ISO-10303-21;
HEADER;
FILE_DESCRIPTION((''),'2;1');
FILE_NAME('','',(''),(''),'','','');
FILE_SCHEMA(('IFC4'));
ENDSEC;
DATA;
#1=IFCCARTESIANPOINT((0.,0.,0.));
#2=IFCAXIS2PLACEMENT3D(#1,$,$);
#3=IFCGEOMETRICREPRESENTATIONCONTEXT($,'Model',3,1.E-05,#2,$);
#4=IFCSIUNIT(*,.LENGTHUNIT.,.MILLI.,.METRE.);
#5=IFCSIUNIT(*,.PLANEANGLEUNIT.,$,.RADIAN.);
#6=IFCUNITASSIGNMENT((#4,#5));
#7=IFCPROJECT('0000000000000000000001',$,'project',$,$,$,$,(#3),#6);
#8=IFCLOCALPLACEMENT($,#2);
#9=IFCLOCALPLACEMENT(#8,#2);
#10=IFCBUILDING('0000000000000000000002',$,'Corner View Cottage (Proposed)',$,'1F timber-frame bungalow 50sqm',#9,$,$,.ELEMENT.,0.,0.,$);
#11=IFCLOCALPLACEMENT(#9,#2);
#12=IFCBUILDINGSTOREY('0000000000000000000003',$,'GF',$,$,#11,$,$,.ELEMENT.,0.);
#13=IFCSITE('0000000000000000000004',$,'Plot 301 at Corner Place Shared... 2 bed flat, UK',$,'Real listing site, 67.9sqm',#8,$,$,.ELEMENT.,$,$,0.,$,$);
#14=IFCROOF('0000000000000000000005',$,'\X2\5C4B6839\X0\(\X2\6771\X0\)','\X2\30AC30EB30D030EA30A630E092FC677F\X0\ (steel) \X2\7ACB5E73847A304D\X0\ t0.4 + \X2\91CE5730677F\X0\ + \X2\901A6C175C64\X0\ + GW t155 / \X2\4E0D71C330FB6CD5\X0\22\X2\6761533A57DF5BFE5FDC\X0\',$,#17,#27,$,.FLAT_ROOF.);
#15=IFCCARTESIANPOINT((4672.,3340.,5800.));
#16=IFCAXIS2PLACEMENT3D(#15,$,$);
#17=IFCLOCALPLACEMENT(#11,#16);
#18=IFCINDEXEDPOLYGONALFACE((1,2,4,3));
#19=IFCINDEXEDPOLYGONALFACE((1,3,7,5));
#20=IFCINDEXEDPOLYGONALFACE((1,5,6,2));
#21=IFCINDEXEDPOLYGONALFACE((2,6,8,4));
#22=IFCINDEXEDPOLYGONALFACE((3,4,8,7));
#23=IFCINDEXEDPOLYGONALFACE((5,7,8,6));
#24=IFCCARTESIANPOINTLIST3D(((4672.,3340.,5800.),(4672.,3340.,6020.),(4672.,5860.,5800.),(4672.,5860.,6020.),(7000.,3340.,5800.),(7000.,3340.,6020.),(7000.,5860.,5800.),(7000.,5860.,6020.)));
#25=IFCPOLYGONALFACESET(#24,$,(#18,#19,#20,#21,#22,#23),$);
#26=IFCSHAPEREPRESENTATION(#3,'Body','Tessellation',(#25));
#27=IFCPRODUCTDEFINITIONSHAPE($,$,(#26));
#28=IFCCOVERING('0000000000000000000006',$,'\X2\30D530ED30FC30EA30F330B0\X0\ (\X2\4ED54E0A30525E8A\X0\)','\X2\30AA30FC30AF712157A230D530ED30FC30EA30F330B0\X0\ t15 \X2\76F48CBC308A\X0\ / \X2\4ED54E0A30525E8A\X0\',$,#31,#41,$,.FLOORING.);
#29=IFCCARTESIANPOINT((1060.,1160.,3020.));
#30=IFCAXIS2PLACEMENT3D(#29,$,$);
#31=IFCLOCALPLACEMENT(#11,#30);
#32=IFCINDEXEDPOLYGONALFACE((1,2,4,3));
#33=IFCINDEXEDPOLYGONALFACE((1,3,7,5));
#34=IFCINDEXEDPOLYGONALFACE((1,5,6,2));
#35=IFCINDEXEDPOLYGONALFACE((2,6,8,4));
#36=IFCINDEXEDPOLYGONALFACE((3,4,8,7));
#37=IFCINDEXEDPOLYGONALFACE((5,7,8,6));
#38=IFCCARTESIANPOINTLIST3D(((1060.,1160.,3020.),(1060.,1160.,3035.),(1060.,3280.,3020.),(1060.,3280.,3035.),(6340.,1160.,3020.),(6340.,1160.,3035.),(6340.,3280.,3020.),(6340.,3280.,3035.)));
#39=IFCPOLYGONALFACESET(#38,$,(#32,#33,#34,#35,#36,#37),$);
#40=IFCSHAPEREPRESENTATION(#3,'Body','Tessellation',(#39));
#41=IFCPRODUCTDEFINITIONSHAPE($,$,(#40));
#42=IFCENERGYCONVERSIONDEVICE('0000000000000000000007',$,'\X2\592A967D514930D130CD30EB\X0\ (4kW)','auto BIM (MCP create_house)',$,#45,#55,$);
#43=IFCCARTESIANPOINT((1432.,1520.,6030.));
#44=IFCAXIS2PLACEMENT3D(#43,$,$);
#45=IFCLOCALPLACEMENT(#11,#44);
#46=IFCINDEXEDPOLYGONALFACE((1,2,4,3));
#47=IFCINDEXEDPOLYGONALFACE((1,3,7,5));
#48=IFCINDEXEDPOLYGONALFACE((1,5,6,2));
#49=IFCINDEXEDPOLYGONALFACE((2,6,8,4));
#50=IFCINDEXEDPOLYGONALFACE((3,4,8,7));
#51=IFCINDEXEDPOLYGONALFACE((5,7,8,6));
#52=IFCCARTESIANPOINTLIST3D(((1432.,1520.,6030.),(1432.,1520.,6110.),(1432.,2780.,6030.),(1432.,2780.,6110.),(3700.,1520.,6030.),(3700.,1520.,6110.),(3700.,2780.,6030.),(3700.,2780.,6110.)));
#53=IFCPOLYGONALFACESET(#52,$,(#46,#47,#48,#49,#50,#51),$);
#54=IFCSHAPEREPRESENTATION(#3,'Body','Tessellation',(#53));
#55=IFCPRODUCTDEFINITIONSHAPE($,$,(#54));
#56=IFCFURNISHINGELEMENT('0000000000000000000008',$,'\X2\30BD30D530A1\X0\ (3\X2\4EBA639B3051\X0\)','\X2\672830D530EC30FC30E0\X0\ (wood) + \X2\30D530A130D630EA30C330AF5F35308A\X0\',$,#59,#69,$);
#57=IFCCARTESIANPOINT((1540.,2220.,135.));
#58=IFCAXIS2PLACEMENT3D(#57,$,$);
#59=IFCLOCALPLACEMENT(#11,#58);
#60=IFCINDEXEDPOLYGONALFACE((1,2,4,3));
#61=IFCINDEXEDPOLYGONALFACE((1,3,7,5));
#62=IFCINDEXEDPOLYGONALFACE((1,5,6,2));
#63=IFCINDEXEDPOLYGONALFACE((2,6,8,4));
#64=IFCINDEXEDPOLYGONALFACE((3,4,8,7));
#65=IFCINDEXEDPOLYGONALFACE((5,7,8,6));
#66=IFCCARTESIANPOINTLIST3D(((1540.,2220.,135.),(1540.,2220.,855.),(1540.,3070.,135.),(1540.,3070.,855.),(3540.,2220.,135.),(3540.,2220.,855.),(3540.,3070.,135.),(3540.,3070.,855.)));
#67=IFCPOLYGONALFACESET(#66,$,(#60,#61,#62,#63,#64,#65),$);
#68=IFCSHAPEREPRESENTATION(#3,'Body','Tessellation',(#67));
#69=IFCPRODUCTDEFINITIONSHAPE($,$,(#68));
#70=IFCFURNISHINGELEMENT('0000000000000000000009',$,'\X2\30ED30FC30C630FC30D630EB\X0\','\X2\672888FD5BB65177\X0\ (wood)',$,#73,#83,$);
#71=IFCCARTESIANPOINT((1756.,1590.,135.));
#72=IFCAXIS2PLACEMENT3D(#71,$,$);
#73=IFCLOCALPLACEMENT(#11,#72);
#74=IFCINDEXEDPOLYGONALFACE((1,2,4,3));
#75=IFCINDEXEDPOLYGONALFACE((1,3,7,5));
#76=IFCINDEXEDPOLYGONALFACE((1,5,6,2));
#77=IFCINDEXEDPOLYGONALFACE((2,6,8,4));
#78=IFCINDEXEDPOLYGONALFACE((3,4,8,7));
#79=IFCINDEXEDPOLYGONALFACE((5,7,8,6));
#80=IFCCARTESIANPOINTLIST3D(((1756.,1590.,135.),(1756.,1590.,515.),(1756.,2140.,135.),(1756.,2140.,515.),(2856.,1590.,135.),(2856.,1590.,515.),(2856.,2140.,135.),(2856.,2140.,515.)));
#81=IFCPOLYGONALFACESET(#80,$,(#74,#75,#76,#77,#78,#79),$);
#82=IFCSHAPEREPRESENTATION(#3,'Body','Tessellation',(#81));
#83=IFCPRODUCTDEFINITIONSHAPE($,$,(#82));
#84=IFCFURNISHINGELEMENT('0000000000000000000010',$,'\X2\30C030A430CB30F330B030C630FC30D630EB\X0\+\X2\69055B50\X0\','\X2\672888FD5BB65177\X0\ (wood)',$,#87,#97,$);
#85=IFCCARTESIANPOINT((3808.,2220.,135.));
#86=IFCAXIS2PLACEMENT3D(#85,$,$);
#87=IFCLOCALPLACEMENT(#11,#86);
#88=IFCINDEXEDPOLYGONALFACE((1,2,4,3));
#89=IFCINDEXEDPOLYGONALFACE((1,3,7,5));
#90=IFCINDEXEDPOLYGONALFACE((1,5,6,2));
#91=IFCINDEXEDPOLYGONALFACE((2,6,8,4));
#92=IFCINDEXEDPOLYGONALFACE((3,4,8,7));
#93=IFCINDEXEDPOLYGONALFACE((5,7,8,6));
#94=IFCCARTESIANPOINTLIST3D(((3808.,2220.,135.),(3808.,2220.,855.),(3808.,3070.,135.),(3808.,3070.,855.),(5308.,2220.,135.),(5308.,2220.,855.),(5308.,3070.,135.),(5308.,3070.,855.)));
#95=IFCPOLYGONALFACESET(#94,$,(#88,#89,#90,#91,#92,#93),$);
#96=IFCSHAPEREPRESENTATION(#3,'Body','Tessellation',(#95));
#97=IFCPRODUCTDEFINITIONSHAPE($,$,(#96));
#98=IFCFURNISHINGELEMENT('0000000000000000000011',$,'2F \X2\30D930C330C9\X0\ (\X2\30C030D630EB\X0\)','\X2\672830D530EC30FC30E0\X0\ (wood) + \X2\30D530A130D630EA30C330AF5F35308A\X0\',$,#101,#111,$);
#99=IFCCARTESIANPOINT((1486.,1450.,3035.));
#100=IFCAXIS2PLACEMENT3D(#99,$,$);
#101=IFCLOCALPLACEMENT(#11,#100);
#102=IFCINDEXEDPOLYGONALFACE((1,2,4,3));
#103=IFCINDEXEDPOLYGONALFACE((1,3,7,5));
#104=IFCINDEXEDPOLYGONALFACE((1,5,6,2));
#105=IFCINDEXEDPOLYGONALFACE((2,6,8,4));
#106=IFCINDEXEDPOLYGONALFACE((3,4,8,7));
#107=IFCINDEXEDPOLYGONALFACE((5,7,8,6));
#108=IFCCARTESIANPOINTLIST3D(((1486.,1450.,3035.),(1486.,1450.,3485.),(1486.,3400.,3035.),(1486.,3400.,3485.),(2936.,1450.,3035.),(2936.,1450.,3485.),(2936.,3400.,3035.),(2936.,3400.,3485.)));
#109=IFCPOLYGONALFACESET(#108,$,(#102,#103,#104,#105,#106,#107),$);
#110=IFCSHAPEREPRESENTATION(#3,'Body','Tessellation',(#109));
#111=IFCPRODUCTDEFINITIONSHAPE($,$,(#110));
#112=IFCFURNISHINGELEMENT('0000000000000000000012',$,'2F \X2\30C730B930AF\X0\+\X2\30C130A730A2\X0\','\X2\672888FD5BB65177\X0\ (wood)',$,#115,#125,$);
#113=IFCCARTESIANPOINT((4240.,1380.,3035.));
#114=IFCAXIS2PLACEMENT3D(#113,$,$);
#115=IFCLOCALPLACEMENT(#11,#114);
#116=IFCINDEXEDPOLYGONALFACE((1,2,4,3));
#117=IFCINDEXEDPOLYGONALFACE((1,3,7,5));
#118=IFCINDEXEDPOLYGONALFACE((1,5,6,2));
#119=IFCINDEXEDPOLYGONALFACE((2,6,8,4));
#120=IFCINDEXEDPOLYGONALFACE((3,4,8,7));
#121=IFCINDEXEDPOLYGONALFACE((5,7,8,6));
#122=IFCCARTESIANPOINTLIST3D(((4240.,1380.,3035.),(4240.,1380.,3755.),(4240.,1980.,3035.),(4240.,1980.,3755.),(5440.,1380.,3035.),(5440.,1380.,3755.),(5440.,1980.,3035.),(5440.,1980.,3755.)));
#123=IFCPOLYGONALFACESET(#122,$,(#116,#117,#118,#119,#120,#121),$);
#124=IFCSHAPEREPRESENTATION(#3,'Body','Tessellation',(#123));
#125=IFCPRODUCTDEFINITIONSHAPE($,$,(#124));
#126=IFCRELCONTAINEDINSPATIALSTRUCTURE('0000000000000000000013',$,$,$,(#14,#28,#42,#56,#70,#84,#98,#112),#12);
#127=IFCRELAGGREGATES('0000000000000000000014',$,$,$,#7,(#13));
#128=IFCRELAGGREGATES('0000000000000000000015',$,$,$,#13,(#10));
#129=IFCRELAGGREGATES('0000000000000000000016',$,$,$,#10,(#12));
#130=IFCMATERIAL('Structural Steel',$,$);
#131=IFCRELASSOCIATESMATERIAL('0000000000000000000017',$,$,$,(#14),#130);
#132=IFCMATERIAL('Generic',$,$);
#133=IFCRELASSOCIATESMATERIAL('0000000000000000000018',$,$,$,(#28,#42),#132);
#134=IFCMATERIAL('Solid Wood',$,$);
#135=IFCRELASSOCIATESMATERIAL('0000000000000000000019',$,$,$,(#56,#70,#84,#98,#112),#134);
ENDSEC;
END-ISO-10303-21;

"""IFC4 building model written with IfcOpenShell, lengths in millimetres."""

from ifc_helpers import new_model, si_unit, frame, frame_2d, origin, place, context, project, spatial, rectangle, extrude, material, element, save


model = new_model("IFC4")

# Units and contexts
model_context = context("Model", 3, precision=1e-05, world=origin())
ifc_project = project(units=[si_unit("LENGTHUNIT", "METRE", prefix="MILLI"), si_unit("PLANEANGLEUNIT", "RADIAN")], contexts=[model_context])

# Site, building, storey
site_placement = place(None, origin())
site = spatial("IfcSite", under=ifc_project, at=site_placement, Name="Plot 301 at Corner Place Shared... 2 bed flat, UK", ObjectType="Real listing site, 67.9sqm", CompositionType="ELEMENT", RefElevation=0.0)
building_placement = place(site_placement, origin())
building = spatial("IfcBuilding", under=site, at=building_placement, Name="Corner View Cottage (Proposed)", ObjectType="1F timber-frame bungalow 50sqm", CompositionType="ELEMENT", ElevationOfRefHeight=0.0, ElevationOfTerrain=0.0)
storey_placement = place(building_placement, origin())
storey = spatial("IfcBuildingStorey", under=building, at=storey_placement, Name="GF", CompositionType="ELEMENT", Elevation=0.0)

# Shared definitions
ifc_material_1 = material(Name="Solid Wood")

# Roof
ifc_material_2 = material(Name="Structural Steel")
roof_1_placement = place(storey_placement, frame((4672.0, 3340.0, 5800.0)))
element("IfcRoof", 1, at=roof_1_placement, inside=storey, material=ifc_material_2, Name="屋根(東)", Description="ガルバリウム鋼板 (steel) 立平葺き t0.4 + 野地板 + 通気層 + GW t155 / 不燃・法22条区域対応", PredefinedType="FLAT_ROOF", context=model_context, shape_type="SweptSolid", body=[
    extrude(rectangle(XDim=2328.0, YDim=2520.0, at=frame_2d((1164.0, 1260.0))), frame((4672.0, 3340.0, 5800.0)), (0.0, 0.0, 1.0), 220.0),
])

# Covering
ifc_material_3 = material(Name="Generic")
covering_placement = place(storey_placement, frame((1060.0, 1160.0, 3020.0)))
element("IfcCovering", 2, at=covering_placement, inside=storey, material=ifc_material_3, Name="フローリング (仕上げ床)", Description="オーク無垢フローリング t15 直貼り / 仕上げ床", PredefinedType="FLOORING", context=model_context, shape_type="SweptSolid", body=[
    extrude(rectangle(XDim=5280.0, YDim=2120.0, at=frame_2d((2640.0, 1060.0))), frame((1060.0, 1160.0, 3020.0)), (0.0, 0.0, 1.0), 15.0),
])

# Energy conversion device
energy_conversion_device_placement = place(storey_placement, frame((1432.0, 1520.0, 6030.0)))
element("IfcEnergyConversionDevice", 3, at=energy_conversion_device_placement, inside=storey, material=ifc_material_3, Name="太陽光パネル (4kW)", Description="auto BIM (MCP create_house)", context=model_context, shape_type="SweptSolid", body=[
    extrude(rectangle(XDim=2268.0, YDim=1260.0, at=frame_2d((1134.0, 630.0))), frame((1432.0, 1520.0, 6030.0)), (0.0, 0.0, 1.0), 80.0),
])

# Furnishing elements
furnishing_1_placement = place(storey_placement, frame((1540.0, 2220.0, 135.0)))
element("IfcFurnishingElement", 4, at=furnishing_1_placement, inside=storey, material=ifc_material_1, Name="ソファ (3人掛け)", Description="木フレーム (wood) + ファブリック張り", context=model_context, shape_type="SweptSolid", body=[
    extrude(rectangle(XDim=2000.0, YDim=850.0, at=frame_2d((1000.0, 425.0))), frame((1540.0, 2220.0, 135.0)), (0.0, 0.0, 1.0), 720.0),
])
furnishing_2_placement = place(storey_placement, frame((1756.0, 1590.0, 135.0)))
element("IfcFurnishingElement", 5, at=furnishing_2_placement, inside=storey, material=ifc_material_1, Name="ローテーブル", Description="木製家具 (wood)", context=model_context, shape_type="SweptSolid", body=[
    extrude(rectangle(XDim=1100.0, YDim=550.0, at=frame_2d((550.0, 275.0))), frame((1756.0, 1590.0, 135.0)), (0.0, 0.0, 1.0), 380.0),
])
furnishing_3_placement = place(storey_placement, frame((3808.0, 2220.0, 135.0)))
element("IfcFurnishingElement", 6, at=furnishing_3_placement, inside=storey, material=ifc_material_1, Name="ダイニングテーブル+椅子", Description="木製家具 (wood)", context=model_context, shape_type="SweptSolid", body=[
    extrude(rectangle(XDim=1500.0, YDim=850.0, at=frame_2d((750.0, 425.0))), frame((3808.0, 2220.0, 135.0)), (0.0, 0.0, 1.0), 720.0),
])
furnishing_4_placement = place(storey_placement, frame((1486.0, 1450.0, 3035.0)))
element("IfcFurnishingElement", 7, at=furnishing_4_placement, inside=storey, material=ifc_material_1, Name="2F ベッド (ダブル)", Description="木フレーム (wood) + ファブリック張り", context=model_context, shape_type="SweptSolid", body=[
    extrude(rectangle(XDim=1450.0, YDim=1950.0, at=frame_2d((725.0, 975.0))), frame((1486.0, 1450.0, 3035.0)), (0.0, 0.0, 1.0), 450.0),
])
furnishing_5_placement = place(storey_placement, frame((4240.0, 1380.0, 3035.0)))
element("IfcFurnishingElement", 8, at=furnishing_5_placement, inside=storey, material=ifc_material_1, Name="2F デスク+チェア", Description="木製家具 (wood)", context=model_context, shape_type="SweptSolid", body=[
    extrude(rectangle(XDim=1200.0, YDim=600.0, at=frame_2d((600.0, 300.0))), frame((4240.0, 1380.0, 3035.0)), (0.0, 0.0, 1.0), 720.0),
])

save(model, "model.ifc")
